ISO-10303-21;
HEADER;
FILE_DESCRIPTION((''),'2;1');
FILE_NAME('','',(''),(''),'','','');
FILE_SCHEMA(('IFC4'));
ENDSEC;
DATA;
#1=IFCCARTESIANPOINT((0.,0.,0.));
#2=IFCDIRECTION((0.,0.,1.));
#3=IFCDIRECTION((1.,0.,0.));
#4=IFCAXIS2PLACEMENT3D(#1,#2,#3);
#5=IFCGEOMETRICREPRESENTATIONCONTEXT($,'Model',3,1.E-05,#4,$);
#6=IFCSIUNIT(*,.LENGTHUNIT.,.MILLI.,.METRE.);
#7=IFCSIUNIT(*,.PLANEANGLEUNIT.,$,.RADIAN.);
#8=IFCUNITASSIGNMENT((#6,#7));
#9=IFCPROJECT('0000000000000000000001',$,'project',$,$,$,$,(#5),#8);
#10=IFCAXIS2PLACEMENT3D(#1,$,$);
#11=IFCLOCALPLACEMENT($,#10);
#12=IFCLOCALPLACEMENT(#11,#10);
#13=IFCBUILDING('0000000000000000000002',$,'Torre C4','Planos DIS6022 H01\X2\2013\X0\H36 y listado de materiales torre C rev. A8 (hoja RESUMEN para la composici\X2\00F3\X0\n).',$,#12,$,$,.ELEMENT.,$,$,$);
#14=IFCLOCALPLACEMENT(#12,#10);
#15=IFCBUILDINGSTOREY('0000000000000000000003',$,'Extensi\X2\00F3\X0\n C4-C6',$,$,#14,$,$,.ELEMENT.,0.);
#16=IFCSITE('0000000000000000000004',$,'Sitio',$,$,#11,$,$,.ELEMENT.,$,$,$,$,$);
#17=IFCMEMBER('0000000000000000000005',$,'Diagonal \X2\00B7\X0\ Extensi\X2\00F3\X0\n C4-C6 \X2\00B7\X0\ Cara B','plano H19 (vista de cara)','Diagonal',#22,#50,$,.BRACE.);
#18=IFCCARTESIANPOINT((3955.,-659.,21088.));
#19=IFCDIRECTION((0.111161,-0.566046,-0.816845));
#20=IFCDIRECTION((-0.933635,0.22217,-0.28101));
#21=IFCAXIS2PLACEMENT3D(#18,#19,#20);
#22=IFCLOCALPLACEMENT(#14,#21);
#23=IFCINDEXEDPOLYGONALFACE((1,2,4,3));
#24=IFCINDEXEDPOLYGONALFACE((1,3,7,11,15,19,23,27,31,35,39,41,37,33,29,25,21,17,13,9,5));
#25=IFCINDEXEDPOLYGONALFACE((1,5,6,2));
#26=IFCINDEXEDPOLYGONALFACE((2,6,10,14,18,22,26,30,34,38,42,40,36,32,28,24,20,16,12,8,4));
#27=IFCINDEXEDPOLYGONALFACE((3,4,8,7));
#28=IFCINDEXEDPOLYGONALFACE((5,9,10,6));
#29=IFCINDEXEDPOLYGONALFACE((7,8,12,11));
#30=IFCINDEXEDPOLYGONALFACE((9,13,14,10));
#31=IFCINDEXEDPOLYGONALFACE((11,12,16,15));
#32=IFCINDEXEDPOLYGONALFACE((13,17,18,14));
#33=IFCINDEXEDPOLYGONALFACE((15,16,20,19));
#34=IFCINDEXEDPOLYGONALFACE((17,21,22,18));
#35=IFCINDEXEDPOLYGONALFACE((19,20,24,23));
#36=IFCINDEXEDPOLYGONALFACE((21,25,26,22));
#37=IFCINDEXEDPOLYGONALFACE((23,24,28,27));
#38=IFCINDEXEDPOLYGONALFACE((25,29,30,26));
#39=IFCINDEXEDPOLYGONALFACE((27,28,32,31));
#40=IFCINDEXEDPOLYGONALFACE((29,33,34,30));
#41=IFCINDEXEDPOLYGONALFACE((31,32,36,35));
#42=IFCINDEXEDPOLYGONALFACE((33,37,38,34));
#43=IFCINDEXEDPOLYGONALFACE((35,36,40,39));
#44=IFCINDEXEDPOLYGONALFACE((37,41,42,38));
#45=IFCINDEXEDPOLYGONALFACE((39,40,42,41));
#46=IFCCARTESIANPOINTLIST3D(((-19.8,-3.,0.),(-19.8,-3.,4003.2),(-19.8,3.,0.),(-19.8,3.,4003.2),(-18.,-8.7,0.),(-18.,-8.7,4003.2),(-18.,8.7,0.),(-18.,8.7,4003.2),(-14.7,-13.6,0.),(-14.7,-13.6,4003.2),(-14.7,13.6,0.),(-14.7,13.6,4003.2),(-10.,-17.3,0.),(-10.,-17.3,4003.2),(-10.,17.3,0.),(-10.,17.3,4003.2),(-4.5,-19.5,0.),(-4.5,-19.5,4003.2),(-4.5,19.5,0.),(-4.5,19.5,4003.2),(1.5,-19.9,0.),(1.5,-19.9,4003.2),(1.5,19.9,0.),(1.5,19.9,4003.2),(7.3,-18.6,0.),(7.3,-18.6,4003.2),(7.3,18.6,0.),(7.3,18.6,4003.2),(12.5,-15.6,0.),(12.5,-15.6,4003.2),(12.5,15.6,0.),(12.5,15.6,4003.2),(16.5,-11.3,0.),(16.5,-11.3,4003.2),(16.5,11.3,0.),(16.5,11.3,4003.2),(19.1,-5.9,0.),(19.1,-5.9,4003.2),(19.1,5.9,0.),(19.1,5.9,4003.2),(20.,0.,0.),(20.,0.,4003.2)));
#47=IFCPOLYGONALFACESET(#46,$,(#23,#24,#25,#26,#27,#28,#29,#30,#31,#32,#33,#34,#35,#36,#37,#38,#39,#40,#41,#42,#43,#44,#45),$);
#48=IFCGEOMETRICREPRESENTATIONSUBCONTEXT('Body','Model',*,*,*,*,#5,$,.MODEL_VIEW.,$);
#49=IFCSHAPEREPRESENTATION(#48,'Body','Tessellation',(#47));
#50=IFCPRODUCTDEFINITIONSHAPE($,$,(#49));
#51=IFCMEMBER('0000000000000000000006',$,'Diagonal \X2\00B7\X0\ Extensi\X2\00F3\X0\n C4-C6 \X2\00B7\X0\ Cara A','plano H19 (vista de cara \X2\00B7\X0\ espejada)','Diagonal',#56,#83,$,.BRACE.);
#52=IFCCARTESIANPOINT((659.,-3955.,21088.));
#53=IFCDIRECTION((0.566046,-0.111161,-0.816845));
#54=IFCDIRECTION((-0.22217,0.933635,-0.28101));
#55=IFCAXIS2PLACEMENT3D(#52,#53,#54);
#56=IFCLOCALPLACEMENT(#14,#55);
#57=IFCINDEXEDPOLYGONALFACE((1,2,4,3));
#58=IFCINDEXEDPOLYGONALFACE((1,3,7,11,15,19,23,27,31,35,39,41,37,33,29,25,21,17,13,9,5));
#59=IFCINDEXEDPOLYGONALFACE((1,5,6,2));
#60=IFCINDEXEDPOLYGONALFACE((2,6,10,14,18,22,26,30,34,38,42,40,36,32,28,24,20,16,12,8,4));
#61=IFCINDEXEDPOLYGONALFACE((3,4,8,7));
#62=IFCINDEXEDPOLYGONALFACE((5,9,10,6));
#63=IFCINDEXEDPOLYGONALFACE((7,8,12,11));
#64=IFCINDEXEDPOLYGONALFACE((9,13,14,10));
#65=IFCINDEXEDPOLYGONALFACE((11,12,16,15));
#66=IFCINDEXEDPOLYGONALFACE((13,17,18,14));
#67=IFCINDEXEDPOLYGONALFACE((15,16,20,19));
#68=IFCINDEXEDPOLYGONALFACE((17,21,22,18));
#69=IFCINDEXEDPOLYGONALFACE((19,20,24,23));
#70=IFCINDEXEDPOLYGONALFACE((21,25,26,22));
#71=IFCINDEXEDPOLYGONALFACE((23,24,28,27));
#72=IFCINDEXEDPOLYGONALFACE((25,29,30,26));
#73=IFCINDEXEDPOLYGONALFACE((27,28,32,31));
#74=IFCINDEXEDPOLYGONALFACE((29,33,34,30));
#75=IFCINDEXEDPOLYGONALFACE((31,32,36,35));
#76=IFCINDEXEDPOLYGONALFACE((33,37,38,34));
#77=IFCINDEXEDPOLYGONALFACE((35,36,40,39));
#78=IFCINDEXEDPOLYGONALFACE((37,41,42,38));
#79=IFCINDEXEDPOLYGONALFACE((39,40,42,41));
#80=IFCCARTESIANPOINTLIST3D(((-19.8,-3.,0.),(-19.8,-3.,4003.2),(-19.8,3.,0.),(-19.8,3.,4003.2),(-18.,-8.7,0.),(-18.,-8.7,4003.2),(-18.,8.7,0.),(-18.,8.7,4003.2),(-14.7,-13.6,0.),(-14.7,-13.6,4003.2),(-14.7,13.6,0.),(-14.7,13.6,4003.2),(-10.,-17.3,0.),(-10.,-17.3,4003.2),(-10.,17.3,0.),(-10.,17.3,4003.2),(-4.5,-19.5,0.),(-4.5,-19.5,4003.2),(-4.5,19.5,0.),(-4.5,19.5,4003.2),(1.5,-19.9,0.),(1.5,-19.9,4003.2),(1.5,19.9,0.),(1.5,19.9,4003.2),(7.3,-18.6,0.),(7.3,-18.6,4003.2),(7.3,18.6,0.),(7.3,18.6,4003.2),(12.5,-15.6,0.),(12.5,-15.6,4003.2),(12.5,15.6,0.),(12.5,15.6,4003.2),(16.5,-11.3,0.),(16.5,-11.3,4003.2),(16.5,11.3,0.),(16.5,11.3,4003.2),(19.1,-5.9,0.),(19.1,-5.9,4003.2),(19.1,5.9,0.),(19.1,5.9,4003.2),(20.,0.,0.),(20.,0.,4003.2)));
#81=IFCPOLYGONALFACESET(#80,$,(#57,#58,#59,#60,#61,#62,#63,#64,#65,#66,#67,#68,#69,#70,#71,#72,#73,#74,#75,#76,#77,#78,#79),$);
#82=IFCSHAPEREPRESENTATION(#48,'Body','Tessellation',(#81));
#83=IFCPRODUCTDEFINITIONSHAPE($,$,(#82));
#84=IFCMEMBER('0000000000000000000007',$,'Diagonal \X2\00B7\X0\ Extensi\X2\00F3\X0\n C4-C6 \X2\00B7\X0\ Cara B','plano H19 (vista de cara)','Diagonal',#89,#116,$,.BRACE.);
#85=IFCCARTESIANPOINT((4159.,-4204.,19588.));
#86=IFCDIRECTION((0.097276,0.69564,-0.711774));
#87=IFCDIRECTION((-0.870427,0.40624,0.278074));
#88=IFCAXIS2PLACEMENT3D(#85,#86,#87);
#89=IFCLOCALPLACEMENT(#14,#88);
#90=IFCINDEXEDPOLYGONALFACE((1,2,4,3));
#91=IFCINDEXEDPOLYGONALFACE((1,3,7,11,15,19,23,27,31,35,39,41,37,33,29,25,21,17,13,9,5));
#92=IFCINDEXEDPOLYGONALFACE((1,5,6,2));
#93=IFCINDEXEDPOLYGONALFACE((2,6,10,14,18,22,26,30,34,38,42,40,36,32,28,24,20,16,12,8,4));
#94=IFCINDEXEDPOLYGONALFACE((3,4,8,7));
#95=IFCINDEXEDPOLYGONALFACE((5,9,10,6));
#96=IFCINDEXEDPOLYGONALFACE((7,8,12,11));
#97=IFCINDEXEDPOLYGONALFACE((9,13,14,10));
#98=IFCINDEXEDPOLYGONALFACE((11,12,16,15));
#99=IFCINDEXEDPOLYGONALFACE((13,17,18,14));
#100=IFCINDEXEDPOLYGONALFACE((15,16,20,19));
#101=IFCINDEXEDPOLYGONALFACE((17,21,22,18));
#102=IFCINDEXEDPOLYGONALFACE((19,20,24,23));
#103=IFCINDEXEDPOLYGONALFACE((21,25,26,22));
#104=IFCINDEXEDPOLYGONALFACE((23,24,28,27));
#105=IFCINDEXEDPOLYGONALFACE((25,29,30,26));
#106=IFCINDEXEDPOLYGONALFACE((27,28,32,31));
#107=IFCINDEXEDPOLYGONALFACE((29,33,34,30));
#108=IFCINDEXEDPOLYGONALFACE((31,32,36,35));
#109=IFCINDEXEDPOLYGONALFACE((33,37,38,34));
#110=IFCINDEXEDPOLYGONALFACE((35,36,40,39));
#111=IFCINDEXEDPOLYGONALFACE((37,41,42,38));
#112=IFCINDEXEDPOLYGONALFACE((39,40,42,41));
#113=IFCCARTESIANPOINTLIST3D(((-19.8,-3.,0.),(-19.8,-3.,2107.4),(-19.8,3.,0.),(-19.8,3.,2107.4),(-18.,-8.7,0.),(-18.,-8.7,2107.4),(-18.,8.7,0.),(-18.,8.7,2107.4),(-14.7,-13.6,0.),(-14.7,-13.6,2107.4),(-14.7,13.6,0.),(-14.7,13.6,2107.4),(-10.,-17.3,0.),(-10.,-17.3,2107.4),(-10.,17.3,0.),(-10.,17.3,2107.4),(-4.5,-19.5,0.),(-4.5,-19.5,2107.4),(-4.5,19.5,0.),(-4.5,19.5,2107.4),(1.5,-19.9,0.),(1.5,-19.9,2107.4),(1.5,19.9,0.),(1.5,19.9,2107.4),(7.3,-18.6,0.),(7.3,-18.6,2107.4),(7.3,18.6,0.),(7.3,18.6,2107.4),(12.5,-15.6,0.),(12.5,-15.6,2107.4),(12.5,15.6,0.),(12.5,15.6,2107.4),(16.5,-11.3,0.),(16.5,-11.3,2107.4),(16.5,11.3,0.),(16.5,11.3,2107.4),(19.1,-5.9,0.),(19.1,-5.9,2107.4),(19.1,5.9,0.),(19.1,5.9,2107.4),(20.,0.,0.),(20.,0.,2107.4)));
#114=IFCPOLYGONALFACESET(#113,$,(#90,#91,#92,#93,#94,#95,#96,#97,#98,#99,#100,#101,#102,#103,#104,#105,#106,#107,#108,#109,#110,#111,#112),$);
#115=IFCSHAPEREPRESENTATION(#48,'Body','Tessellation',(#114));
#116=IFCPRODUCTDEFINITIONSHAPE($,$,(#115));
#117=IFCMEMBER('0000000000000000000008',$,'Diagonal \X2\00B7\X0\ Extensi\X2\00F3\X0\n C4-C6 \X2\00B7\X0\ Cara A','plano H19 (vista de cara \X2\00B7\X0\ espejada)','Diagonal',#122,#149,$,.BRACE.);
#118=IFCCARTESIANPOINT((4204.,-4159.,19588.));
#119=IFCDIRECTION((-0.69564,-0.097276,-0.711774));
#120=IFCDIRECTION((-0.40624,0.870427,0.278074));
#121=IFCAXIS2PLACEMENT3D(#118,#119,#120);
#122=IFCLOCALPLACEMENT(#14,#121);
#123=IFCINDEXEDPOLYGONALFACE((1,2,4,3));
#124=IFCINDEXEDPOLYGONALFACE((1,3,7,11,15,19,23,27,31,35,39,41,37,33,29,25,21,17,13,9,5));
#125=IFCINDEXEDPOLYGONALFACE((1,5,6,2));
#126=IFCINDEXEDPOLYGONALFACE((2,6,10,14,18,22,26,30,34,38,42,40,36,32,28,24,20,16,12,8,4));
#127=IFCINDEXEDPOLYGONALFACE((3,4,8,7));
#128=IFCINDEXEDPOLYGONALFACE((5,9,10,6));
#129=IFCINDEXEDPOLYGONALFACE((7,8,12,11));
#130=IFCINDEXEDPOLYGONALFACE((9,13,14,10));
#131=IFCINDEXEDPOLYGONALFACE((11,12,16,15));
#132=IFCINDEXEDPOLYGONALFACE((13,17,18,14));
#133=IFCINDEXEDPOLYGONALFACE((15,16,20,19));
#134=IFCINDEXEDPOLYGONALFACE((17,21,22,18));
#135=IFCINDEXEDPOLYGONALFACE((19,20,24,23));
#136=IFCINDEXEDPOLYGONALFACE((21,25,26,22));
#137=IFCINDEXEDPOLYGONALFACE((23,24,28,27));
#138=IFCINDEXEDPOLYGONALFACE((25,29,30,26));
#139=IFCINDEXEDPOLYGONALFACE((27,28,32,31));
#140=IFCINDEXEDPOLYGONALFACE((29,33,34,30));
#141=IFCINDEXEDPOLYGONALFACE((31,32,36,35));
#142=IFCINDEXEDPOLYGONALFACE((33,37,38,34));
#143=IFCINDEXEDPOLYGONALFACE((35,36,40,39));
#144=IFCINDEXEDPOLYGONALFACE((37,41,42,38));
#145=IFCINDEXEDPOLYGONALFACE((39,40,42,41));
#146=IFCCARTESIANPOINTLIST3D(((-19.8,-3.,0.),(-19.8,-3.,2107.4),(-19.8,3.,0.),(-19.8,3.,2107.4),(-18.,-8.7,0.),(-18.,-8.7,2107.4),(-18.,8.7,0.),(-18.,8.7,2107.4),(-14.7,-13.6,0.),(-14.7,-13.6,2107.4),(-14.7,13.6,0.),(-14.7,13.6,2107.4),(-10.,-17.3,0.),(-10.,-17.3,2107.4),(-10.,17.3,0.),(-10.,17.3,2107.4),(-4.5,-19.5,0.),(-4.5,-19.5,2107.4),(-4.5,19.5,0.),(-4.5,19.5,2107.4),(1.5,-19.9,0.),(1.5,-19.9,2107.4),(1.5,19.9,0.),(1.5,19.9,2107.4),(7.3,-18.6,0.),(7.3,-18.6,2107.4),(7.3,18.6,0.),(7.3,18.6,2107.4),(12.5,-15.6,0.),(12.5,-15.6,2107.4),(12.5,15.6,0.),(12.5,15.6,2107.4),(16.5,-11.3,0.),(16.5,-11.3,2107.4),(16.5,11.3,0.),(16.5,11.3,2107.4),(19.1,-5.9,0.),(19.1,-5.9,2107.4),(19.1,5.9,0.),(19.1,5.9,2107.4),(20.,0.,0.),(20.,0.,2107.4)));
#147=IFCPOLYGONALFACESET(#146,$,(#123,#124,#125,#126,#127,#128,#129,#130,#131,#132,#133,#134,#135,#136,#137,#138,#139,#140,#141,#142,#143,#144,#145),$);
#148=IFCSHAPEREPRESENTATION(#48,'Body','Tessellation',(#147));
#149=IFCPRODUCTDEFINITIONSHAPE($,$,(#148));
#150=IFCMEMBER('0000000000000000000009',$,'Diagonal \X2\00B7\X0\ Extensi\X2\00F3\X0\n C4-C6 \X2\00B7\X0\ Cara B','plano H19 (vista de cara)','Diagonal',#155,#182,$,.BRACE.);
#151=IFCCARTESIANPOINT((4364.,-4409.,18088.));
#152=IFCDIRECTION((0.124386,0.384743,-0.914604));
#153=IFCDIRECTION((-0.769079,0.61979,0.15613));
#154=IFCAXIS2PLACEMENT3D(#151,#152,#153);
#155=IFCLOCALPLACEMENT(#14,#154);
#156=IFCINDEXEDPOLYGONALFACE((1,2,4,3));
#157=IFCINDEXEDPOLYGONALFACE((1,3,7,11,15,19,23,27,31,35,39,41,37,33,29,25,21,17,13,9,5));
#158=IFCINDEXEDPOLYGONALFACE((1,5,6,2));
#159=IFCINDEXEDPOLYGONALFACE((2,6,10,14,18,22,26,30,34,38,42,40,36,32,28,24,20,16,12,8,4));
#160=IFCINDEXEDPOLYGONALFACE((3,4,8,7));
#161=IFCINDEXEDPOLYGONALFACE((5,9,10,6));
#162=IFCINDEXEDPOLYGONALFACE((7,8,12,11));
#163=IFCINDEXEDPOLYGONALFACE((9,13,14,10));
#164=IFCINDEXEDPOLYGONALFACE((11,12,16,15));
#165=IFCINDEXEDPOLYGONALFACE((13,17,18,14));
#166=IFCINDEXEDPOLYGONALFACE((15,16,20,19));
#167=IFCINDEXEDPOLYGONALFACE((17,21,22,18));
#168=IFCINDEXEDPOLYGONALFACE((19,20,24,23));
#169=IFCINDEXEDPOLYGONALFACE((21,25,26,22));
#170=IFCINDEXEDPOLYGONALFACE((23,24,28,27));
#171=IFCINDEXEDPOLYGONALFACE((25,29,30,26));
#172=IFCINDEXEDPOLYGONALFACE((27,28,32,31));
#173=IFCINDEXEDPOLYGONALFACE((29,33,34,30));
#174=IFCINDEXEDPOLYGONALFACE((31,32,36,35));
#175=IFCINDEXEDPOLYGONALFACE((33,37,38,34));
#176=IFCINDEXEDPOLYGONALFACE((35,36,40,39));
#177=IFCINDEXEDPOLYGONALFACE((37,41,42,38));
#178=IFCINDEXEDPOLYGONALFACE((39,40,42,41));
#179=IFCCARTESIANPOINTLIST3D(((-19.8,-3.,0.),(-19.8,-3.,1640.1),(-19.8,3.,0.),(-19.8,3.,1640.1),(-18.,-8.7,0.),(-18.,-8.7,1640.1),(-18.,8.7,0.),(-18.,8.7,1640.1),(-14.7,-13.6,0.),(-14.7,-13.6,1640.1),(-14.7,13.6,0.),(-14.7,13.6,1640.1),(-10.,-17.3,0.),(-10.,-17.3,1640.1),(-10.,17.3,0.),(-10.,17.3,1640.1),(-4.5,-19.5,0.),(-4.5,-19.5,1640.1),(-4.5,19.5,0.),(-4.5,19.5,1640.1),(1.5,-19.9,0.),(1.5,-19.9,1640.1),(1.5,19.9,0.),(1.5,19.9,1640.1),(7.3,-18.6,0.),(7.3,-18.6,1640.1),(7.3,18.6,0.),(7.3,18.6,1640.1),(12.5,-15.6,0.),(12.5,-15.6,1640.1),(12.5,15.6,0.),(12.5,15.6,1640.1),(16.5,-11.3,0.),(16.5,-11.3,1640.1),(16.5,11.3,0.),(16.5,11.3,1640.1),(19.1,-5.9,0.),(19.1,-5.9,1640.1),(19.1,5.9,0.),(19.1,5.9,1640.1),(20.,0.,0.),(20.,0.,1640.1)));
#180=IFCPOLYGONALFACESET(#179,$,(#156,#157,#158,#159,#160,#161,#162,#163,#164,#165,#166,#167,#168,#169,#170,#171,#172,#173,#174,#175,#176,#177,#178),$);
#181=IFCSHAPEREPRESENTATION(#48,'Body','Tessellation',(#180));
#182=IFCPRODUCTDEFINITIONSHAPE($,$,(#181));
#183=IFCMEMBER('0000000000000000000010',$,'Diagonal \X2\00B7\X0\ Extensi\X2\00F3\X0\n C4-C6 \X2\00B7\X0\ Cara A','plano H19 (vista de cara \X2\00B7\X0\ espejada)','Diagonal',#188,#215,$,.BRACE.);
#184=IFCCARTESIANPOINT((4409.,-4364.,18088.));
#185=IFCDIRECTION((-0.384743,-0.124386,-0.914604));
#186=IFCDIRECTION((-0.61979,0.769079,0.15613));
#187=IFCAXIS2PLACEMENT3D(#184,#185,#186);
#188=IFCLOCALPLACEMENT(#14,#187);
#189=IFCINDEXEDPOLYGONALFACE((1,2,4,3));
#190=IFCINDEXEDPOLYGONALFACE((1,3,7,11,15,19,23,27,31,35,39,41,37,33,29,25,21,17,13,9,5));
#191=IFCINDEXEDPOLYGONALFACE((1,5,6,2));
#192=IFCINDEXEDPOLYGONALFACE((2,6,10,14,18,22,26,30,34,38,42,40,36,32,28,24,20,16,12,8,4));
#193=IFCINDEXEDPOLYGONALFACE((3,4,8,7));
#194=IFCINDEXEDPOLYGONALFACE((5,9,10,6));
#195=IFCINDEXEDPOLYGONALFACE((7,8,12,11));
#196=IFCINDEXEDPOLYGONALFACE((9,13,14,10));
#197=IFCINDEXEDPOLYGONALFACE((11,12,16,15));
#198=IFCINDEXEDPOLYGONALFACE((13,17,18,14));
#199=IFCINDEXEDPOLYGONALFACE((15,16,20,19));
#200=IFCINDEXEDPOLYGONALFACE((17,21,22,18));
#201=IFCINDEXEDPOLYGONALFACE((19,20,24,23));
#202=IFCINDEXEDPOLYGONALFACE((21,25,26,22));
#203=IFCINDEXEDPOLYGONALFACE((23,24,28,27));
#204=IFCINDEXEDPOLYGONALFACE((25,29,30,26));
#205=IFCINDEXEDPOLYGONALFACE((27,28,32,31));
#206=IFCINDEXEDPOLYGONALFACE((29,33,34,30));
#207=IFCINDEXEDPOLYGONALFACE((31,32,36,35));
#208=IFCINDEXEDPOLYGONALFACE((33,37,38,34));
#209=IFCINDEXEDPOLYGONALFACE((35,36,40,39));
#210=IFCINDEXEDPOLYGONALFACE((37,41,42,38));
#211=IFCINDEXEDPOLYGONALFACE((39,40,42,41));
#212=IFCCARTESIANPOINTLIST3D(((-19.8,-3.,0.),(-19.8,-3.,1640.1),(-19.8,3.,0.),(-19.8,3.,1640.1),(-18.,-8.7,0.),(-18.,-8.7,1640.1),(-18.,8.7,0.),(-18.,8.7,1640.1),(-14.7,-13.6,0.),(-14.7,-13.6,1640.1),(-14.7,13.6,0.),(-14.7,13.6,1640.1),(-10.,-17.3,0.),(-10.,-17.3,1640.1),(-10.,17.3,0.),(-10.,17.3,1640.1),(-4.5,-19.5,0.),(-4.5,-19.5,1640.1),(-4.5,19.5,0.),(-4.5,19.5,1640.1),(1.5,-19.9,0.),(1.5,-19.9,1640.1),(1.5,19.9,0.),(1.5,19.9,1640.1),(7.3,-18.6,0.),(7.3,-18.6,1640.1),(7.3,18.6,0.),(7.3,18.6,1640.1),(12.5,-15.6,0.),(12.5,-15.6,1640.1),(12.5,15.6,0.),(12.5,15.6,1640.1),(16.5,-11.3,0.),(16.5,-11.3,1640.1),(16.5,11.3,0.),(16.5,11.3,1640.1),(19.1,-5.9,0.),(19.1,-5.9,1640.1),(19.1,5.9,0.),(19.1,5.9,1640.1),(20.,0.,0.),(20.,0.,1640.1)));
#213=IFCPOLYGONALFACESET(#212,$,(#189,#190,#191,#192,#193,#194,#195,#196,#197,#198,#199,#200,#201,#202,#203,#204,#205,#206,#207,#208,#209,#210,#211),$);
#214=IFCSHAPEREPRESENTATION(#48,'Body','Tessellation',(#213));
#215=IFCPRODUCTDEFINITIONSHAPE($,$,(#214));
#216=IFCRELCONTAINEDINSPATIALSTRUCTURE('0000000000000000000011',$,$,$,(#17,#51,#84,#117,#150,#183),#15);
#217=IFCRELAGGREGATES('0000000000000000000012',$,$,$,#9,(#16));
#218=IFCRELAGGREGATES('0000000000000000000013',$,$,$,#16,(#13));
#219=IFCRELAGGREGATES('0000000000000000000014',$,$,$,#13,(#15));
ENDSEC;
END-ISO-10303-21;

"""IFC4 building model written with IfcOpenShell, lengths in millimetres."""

from ifc_helpers import new_model, si_unit, frame, origin, origin_with_axes, place, context, subcontext, project, spatial, circle, extrude, element, save


model = new_model("IFC4")

# Units and contexts
model_context = context("Model", 3, precision=1e-05, world=origin_with_axes())
body_context = subcontext(model_context, "Body", "Model", "MODEL_VIEW")
ifc_project = project(units=[si_unit("LENGTHUNIT", "METRE", prefix="MILLI"), si_unit("PLANEANGLEUNIT", "RADIAN")], contexts=[model_context])

# Site, building, storey
site_placement = place(None, origin())
site = spatial("IfcSite", under=ifc_project, at=site_placement, Name="Sitio", CompositionType="ELEMENT")
building_placement = place(site_placement, origin())
building = spatial("IfcBuilding", under=site, at=building_placement, Name="Torre C4", Description="Planos DIS6022 H01–H36 y listado de materiales torre C rev. A8 (hoja RESUMEN para la composición).", CompositionType="ELEMENT")
storey_placement = place(building_placement, origin())
storey = spatial("IfcBuildingStorey", under=building, at=storey_placement, Name="Extensión C4-C6", CompositionType="ELEMENT", Elevation=0.0)

# Members
for number, where, z_axis, x_axis, name, description in (
    (1, (3955.0, -659.0, 21088.0), (0.111161, -0.566046, -0.816845), (-0.933635, 0.22217, -0.28101), "Diagonal · Extensión C4-C6 · Cara B", "plano H19 (vista de cara)"),
    (2, (659.0, -3955.0, 21088.0), (0.566046, -0.111161, -0.816845), (-0.22217, 0.933635, -0.28101), "Diagonal · Extensión C4-C6 · Cara A", "plano H19 (vista de cara · espejada)"),
):
    element("IfcMember", number, at=place(storey_placement, frame(where, z_axis=z_axis, x_axis=x_axis)), inside=storey, Name=name, Description=description, ObjectType="Diagonal", PredefinedType="BRACE", context=body_context, shape_type="SweptSolid", body=[
        extrude(circle(Radius=20.0), None, (0.0, 0.0, 1.0), 4003.2),
    ])
for number, where, z_axis, x_axis, name, description in (
    (3, (4159.0, -4204.0, 19588.0), (0.097276, 0.69564, -0.711774), (-0.870427, 0.40624, 0.278074), "Diagonal · Extensión C4-C6 · Cara B", "plano H19 (vista de cara)"),
    (4, (4204.0, -4159.0, 19588.0), (-0.69564, -0.097276, -0.711774), (-0.40624, 0.870427, 0.278074), "Diagonal · Extensión C4-C6 · Cara A", "plano H19 (vista de cara · espejada)"),
):
    element("IfcMember", number, at=place(storey_placement, frame(where, z_axis=z_axis, x_axis=x_axis)), inside=storey, Name=name, Description=description, ObjectType="Diagonal", PredefinedType="BRACE", context=body_context, shape_type="SweptSolid", body=[
        extrude(circle(Radius=20.0), None, (0.0, 0.0, 1.0), 2107.4),
    ])
for number, where, z_axis, x_axis, name, description in (
    (5, (4364.0, -4409.0, 18088.0), (0.124386, 0.384743, -0.914604), (-0.769079, 0.61979, 0.15613), "Diagonal · Extensión C4-C6 · Cara B", "plano H19 (vista de cara)"),
    (6, (4409.0, -4364.0, 18088.0), (-0.384743, -0.124386, -0.914604), (-0.61979, 0.769079, 0.15613), "Diagonal · Extensión C4-C6 · Cara A", "plano H19 (vista de cara · espejada)"),
):
    element("IfcMember", number, at=place(storey_placement, frame(where, z_axis=z_axis, x_axis=x_axis)), inside=storey, Name=name, Description=description, ObjectType="Diagonal", PredefinedType="BRACE", context=body_context, shape_type="SweptSolid", body=[
        extrude(circle(Radius=20.0), None, (0.0, 0.0, 1.0), 1640.1),
    ])

save(model, "model.ifc")
